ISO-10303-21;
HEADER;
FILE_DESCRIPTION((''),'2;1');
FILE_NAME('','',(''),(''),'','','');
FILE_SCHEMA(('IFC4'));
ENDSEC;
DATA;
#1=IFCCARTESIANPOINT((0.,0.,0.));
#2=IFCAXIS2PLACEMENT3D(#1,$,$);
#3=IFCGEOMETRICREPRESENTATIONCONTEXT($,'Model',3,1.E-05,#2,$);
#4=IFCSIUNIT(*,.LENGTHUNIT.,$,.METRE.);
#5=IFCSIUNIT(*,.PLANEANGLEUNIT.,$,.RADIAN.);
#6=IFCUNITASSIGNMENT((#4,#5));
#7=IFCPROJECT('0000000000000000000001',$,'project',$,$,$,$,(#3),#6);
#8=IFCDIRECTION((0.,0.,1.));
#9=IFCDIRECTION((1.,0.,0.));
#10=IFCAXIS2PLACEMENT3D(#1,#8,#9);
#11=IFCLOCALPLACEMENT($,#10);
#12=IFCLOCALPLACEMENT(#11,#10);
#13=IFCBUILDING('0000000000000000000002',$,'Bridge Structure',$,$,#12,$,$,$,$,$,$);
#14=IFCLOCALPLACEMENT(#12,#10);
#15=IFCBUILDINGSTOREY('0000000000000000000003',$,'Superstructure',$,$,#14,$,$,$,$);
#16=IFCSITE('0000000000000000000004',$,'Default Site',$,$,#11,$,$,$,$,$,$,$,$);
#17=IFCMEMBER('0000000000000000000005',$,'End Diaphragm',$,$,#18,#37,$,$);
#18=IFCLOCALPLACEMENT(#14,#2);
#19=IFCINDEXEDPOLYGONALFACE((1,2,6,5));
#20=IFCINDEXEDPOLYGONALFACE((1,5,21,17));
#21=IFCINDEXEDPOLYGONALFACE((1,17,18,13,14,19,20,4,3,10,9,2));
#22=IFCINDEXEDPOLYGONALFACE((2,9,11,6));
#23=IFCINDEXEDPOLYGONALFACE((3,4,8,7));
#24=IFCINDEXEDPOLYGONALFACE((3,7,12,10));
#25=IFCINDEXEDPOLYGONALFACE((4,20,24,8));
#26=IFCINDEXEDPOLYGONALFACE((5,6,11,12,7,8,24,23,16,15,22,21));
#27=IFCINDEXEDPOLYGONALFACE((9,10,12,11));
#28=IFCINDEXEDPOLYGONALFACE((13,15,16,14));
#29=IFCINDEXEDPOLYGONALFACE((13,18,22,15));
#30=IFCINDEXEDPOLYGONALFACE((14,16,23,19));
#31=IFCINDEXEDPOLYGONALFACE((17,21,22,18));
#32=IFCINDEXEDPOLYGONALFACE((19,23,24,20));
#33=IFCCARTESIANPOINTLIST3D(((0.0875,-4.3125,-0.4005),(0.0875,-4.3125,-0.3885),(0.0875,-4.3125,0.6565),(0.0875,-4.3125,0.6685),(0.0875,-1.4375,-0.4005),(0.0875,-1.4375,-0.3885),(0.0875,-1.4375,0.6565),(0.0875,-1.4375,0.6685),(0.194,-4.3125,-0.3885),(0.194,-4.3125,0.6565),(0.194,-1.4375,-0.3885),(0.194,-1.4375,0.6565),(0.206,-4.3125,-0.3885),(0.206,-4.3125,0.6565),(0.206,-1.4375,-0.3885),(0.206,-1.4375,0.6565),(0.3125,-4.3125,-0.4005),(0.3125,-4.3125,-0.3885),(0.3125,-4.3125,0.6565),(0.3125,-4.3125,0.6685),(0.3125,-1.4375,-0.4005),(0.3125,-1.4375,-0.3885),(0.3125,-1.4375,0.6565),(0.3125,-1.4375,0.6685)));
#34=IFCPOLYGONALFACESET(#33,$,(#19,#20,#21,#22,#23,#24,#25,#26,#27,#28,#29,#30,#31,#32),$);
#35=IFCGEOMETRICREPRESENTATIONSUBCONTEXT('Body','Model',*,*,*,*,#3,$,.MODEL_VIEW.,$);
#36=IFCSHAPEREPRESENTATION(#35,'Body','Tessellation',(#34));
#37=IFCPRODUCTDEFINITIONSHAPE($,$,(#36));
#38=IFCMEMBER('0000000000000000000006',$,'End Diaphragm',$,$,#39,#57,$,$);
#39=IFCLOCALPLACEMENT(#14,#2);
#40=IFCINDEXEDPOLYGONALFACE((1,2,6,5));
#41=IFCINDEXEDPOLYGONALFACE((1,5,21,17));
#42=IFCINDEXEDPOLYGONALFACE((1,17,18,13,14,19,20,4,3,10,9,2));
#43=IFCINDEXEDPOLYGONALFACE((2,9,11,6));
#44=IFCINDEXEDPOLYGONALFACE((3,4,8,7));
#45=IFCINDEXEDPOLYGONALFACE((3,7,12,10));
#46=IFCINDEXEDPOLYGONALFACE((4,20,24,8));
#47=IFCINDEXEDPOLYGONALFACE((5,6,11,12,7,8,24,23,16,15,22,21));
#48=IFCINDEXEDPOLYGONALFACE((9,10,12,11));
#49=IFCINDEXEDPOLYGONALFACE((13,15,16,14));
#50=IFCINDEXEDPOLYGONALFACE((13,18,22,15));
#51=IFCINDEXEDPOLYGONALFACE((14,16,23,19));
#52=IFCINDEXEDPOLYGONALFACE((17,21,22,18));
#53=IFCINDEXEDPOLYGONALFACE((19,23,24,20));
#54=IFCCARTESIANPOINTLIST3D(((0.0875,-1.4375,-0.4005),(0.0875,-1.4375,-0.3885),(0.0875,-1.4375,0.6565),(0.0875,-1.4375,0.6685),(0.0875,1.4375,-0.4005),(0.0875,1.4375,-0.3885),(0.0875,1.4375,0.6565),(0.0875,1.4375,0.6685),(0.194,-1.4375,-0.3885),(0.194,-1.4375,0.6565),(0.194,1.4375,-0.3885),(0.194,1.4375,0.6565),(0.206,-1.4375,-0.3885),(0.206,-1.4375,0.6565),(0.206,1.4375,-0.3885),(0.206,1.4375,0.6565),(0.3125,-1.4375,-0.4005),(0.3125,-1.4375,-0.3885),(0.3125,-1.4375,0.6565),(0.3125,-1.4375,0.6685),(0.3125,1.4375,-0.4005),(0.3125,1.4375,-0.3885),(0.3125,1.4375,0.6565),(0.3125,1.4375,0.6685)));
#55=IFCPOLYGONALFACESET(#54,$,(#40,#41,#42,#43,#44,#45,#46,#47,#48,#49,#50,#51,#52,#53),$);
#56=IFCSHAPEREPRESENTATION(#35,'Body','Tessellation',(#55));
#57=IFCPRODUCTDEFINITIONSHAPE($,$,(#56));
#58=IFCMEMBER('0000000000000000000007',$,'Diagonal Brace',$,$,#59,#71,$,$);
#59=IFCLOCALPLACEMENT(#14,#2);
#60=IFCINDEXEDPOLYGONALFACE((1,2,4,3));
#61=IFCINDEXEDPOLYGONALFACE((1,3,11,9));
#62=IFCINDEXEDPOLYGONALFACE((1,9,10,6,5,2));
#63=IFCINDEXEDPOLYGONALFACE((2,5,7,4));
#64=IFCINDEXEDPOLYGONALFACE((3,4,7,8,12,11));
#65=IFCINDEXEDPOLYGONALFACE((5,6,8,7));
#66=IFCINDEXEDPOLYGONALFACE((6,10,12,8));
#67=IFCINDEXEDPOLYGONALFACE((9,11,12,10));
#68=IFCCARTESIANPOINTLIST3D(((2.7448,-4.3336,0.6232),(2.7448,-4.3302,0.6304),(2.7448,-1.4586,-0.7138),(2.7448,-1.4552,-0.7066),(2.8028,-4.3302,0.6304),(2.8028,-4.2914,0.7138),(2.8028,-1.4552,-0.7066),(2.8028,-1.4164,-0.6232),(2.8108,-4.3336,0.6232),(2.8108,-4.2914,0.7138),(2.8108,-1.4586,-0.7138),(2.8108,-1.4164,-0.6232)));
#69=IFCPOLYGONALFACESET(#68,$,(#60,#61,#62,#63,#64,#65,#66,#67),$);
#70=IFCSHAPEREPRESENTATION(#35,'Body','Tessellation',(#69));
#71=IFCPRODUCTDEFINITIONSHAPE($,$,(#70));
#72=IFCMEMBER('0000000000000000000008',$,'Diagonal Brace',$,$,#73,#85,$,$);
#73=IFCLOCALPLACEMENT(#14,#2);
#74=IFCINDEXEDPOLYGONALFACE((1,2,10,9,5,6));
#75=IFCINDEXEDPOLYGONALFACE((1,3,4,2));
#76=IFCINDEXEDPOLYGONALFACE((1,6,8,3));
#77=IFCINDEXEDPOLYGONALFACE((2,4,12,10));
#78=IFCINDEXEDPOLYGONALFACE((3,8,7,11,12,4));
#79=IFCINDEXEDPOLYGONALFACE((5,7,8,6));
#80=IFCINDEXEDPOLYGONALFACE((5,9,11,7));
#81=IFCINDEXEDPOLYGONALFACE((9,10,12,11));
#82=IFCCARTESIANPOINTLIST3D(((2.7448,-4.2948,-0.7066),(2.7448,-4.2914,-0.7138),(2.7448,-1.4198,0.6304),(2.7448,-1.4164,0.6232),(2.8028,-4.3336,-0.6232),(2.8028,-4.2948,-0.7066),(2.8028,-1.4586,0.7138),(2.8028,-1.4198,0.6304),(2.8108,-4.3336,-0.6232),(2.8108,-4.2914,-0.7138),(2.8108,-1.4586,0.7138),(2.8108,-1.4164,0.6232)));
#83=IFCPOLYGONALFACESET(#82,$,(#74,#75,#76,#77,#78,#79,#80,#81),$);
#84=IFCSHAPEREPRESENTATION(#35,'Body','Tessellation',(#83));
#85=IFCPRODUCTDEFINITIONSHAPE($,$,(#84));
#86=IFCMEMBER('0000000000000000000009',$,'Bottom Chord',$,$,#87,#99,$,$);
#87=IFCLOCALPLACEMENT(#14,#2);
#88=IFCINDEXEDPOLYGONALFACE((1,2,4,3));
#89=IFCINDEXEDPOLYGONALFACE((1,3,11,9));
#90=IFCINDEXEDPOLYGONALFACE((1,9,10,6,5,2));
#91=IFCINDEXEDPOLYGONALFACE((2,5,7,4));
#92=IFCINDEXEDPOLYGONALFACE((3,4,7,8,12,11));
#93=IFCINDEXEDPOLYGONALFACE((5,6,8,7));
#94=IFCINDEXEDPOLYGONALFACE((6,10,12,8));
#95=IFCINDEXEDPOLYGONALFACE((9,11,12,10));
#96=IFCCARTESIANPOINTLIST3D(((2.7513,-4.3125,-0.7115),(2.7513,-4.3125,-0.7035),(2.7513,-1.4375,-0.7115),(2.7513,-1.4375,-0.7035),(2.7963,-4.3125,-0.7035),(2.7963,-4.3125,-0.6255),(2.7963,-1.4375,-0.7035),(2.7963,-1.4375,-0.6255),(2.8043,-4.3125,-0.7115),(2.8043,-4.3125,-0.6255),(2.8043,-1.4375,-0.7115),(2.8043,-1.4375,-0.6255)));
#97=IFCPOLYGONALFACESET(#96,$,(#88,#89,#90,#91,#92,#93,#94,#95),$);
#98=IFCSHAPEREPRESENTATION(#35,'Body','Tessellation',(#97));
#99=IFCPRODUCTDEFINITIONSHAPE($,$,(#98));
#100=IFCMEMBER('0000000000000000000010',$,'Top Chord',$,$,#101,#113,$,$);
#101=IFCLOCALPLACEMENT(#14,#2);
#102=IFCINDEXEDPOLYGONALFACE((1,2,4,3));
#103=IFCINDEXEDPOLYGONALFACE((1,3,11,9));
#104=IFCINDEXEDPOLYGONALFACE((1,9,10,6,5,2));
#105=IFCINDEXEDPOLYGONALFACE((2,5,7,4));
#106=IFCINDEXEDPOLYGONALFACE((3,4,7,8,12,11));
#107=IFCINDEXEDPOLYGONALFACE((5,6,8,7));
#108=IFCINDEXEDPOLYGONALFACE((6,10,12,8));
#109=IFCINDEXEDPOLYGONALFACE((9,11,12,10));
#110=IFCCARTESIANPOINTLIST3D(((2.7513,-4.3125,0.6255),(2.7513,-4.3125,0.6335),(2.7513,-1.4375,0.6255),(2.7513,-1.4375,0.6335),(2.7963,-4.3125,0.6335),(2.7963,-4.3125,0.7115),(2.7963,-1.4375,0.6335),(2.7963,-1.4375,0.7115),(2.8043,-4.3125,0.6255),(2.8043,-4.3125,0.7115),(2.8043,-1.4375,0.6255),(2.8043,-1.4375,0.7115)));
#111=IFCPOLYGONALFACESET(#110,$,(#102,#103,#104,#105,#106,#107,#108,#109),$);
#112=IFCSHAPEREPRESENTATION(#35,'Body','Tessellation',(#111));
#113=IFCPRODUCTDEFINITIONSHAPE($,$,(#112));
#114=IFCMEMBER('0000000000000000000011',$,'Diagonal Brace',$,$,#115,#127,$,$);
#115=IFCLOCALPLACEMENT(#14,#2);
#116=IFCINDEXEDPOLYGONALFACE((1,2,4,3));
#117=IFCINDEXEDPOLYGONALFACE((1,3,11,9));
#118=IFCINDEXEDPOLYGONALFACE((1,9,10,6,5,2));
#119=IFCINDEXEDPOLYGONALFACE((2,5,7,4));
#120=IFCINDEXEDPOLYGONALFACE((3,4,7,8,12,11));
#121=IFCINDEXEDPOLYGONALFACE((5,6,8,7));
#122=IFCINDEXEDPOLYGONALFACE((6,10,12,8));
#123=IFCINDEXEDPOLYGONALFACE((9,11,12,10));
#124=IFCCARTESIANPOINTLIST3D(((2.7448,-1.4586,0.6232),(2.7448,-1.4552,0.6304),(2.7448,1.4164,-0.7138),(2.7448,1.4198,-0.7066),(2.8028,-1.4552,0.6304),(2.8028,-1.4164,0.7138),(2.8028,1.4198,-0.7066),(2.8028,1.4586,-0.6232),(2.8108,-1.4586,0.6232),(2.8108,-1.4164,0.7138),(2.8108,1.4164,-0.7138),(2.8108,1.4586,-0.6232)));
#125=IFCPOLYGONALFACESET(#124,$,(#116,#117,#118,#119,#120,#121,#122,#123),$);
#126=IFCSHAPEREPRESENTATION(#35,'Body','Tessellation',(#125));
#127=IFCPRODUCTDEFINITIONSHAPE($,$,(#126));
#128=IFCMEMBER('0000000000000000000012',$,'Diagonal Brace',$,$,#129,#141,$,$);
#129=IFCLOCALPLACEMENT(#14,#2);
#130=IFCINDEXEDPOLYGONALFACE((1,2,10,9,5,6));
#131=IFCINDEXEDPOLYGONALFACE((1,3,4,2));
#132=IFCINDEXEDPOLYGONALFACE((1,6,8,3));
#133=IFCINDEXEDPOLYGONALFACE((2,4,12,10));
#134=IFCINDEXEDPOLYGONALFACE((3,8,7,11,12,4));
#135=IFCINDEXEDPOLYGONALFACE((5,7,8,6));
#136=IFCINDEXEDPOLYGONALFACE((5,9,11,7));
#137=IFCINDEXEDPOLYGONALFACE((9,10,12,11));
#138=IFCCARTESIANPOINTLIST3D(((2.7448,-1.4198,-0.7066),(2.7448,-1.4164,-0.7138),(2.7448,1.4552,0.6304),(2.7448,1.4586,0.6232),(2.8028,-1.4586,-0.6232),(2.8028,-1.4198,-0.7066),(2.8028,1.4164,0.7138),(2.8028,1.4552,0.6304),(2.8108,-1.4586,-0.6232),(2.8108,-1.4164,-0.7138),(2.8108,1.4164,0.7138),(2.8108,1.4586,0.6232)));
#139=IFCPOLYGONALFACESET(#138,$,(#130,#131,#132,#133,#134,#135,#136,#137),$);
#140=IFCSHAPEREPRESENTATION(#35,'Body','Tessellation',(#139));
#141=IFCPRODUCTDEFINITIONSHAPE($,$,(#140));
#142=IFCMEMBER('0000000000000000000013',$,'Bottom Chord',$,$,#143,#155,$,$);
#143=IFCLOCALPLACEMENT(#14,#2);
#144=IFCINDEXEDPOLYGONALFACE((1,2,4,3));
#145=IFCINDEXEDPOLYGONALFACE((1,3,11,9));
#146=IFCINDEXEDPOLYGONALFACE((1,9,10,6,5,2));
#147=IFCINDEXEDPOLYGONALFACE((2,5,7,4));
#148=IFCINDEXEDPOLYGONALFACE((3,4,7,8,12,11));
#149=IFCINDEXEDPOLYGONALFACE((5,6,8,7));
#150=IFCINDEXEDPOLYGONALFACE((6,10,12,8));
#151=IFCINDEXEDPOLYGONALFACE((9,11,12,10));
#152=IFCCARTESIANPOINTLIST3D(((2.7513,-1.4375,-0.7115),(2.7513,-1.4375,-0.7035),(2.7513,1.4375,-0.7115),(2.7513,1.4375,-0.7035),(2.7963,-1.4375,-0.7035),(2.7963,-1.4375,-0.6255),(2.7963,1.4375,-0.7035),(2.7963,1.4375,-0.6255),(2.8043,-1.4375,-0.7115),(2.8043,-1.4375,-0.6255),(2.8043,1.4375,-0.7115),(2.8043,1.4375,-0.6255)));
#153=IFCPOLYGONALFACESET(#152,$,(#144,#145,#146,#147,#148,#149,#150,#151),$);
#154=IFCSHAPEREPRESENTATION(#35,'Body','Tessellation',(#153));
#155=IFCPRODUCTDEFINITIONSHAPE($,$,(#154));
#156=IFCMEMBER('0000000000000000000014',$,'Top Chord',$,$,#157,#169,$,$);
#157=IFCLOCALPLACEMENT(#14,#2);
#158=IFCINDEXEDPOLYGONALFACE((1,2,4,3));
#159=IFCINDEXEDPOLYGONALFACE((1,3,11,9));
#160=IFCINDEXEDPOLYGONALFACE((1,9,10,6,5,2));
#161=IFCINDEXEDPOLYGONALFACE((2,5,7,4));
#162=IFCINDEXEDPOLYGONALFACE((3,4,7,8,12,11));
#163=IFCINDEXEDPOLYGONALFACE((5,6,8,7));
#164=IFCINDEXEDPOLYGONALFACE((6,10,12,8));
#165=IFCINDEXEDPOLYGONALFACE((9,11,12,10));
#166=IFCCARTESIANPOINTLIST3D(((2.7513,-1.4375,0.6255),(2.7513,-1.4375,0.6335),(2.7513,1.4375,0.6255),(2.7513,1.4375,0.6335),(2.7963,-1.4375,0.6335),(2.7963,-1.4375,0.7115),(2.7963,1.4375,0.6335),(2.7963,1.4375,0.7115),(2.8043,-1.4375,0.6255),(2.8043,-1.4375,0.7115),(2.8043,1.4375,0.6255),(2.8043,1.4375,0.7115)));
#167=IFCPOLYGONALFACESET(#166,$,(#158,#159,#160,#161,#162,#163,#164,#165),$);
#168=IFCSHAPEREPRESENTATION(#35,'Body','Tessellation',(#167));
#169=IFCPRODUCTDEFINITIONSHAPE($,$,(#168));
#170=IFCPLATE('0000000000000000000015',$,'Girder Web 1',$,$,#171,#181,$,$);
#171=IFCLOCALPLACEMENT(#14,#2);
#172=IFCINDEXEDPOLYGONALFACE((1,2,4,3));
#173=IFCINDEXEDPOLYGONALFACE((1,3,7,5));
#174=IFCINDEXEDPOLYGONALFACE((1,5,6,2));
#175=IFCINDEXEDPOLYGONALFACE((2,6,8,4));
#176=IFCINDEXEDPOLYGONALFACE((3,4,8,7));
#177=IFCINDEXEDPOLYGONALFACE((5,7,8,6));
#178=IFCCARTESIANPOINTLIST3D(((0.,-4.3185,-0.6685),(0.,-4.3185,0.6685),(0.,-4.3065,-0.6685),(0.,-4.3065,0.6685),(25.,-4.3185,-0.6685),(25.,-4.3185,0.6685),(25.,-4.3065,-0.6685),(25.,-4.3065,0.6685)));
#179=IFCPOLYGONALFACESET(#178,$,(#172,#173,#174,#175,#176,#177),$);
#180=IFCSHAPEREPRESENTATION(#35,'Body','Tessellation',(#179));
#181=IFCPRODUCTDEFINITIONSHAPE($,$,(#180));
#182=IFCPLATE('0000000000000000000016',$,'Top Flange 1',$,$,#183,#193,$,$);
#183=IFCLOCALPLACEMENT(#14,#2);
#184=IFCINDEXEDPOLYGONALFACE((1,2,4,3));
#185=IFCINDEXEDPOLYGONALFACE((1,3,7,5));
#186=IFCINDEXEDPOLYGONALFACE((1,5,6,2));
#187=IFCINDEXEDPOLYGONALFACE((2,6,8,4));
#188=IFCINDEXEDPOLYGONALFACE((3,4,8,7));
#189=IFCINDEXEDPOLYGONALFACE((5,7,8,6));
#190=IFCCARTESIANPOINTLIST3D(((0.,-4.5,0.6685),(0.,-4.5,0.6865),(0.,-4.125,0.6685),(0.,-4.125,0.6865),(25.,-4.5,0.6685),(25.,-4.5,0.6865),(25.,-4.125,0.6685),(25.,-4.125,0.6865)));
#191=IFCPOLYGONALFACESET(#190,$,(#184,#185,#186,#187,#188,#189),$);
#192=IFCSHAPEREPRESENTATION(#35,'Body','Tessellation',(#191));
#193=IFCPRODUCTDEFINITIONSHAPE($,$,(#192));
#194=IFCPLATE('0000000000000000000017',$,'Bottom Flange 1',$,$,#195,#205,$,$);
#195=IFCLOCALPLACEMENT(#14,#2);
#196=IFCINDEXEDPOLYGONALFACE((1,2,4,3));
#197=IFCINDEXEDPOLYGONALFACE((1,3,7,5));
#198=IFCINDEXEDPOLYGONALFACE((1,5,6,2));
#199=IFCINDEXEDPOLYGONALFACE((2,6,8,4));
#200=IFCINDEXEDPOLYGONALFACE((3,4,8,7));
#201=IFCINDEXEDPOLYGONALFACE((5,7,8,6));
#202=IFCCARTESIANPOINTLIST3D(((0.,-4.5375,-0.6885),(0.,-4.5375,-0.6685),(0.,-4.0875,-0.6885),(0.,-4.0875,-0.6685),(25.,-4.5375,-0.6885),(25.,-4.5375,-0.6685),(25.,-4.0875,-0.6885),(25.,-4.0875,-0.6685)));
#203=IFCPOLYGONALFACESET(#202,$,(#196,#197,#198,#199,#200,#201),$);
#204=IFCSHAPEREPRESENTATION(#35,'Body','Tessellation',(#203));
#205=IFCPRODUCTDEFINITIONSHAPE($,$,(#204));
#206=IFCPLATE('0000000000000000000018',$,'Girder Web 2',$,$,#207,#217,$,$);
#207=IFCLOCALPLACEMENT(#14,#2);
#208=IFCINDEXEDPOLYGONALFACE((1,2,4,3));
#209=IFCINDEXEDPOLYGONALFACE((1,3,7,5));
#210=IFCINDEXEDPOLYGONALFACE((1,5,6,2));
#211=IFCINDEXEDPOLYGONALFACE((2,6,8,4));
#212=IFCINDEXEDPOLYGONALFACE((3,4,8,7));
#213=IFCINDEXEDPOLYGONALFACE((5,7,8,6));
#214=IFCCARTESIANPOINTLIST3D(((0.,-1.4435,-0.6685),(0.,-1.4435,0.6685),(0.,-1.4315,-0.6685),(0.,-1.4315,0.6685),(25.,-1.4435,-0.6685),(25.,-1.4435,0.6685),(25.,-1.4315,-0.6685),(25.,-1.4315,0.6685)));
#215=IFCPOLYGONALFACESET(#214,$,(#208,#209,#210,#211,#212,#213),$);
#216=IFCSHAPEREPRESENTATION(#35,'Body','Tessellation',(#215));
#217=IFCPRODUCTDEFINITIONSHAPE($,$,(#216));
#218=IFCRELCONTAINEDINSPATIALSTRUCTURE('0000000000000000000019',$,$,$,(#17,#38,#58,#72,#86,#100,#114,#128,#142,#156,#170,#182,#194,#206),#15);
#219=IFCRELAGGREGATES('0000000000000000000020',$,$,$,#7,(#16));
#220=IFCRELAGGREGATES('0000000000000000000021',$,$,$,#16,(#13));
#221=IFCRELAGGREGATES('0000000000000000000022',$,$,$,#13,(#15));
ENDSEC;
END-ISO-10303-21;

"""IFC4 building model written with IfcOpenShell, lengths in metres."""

from ifc_helpers import new_model, si_unit, frame, origin, origin_with_axes, origin_2d_with_axis, place, context, subcontext, project, spatial, rectangle, i_section, l_section, extrude, element, save


model = new_model("IFC4")

# Units and contexts
model_context = context("Model", 3, precision=1e-05, world=origin())
body_context = subcontext(model_context, "Body", "Model", "MODEL_VIEW")
ifc_project = project(units=[si_unit("LENGTHUNIT", "METRE"), si_unit("PLANEANGLEUNIT", "RADIAN")], contexts=[model_context])

# Site, building, storey
site_placement = place(None, origin_with_axes())
site = spatial("IfcSite", under=ifc_project, at=site_placement, Name="Default Site")
building_placement = place(site_placement, origin_with_axes())
building = spatial("IfcBuilding", under=site, at=building_placement, Name="Bridge Structure")
storey_placement = place(building_placement, origin_with_axes())
storey = spatial("IfcBuildingStorey", under=building, at=storey_placement, Name="Superstructure")

# Members
for number, where, z_axis, x_axis, name in (
    (1, (0.2, -4.3125, 0.134), (0.0, 1.0, 0.0), (-1.0, 0.0, 0.0), "End Diaphragm"),
    (2, (0.2, -1.4375, 0.134), (0.0, 1.0, 0.0), (-1.0, 0.0, 0.0), "End Diaphragm"),
):
    element("IfcMember", number, at=place(storey_placement, frame(where, z_axis=z_axis, x_axis=x_axis)), inside=storey, Name=name, context=body_context, shape_type="SweptSolid", body=[
        extrude(i_section(OverallWidth=0.225, OverallDepth=1.069, WebThickness=0.012, FlangeThickness=0.012, at=origin_2d_with_axis()), origin_with_axes(), (0.0, 0.0, 1.0), 2.875),
    ])
for number, where, z_axis, x_axis, name in (
    (3, (2.7778, -4.3125, 0.6685), (0.0, 0.906746, -0.421676), (-1.0, 0.0, 0.0), "Diagonal Brace"),
    (4, (2.7778, -4.3125, -0.6685), (0.0, 0.906746, 0.421676), (-1.0, 0.0, 0.0), "Diagonal Brace"),
):
    element("IfcMember", number, at=place(storey_placement, frame(where, z_axis=z_axis, x_axis=x_axis)), inside=storey, Name=name, context=body_context, shape_type="SweptSolid", body=[
        extrude(l_section(Depth=0.1, Width=0.066, Thickness=0.008, at=origin_2d_with_axis()), origin_with_axes(), (0.0, 0.0, 1.0), 3.1707),
    ])
for number, where, z_axis, x_axis, name in (
    (5, (2.7778, -4.3125, -0.6685), (0.0, 1.0, 0.0), (-1.0, 0.0, 0.0), "Bottom Chord"),
    (6, (2.7778, -4.3125, 0.6685), (0.0, 1.0, 0.0), (-1.0, 0.0, 0.0), "Top Chord"),
):
    element("IfcMember", number, at=place(storey_placement, frame(where, z_axis=z_axis, x_axis=x_axis)), inside=storey, Name=name, context=body_context, shape_type="SweptSolid", body=[
        extrude(l_section(Depth=0.086, Width=0.053, Thickness=0.008, at=origin_2d_with_axis()), origin_with_axes(), (0.0, 0.0, 1.0), 2.875),
    ])
for number, where, z_axis, x_axis, name in (
    (7, (2.7778, -1.4375, 0.6685), (0.0, 0.906746, -0.421676), (-1.0, 0.0, 0.0), "Diagonal Brace"),
    (8, (2.7778, -1.4375, -0.6685), (0.0, 0.906746, 0.421676), (-1.0, 0.0, 0.0), "Diagonal Brace"),
):
    element("IfcMember", number, at=place(storey_placement, frame(where, z_axis=z_axis, x_axis=x_axis)), inside=storey, Name=name, context=body_context, shape_type="SweptSolid", body=[
        extrude(l_section(Depth=0.1, Width=0.066, Thickness=0.008, at=origin_2d_with_axis()), origin_with_axes(), (0.0, 0.0, 1.0), 3.1707),
    ])
for number, where, z_axis, x_axis, name in (
    (9, (2.7778, -1.4375, -0.6685), (0.0, 1.0, 0.0), (-1.0, 0.0, 0.0), "Bottom Chord"),
    (10, (2.7778, -1.4375, 0.6685), (0.0, 1.0, 0.0), (-1.0, 0.0, 0.0), "Top Chord"),
):
    element("IfcMember", number, at=place(storey_placement, frame(where, z_axis=z_axis, x_axis=x_axis)), inside=storey, Name=name, context=body_context, shape_type="SweptSolid", body=[
        extrude(l_section(Depth=0.086, Width=0.053, Thickness=0.008, at=origin_2d_with_axis()), origin_with_axes(), (0.0, 0.0, 1.0), 2.875),
    ])

# Plates
plate_1_placement = place(storey_placement, frame((0.0, -4.3125, 0.0), z_axis=(1.0, 0.0, 0.0), x_axis=(0.0, 1.0, 0.0)))
element("IfcPlate", 11, at=plate_1_placement, inside=storey, Name="Girder Web 1", context=body_context, shape_type="SweptSolid", body=[
    extrude(rectangle(XDim=0.012, YDim=1.337, at=origin_2d_with_axis()), origin_with_axes(), (0.0, 0.0, 1.0), 25.0),
])
plate_2_placement = place(storey_placement, frame((0.0, -4.3125, 0.6775), z_axis=(1.0, 0.0, 0.0), x_axis=(0.0, 1.0, 0.0)))
element("IfcPlate", 12, at=plate_2_placement, inside=storey, Name="Top Flange 1", context=body_context, shape_type="SweptSolid", body=[
    extrude(rectangle(XDim=0.375, YDim=0.018, at=origin_2d_with_axis()), origin_with_axes(), (0.0, 0.0, 1.0), 25.0),
])
plate_3_placement = place(storey_placement, frame((0.0, -4.3125, -0.6785), z_axis=(1.0, 0.0, 0.0), x_axis=(0.0, 1.0, 0.0)))
element("IfcPlate", 13, at=plate_3_placement, inside=storey, Name="Bottom Flange 1", context=body_context, shape_type="SweptSolid", body=[
    extrude(rectangle(XDim=0.45, YDim=0.02, at=origin_2d_with_axis()), origin_with_axes(), (0.0, 0.0, 1.0), 25.0),
])
plate_4_placement = place(storey_placement, frame((0.0, -1.4375, 0.0), z_axis=(1.0, 0.0, 0.0), x_axis=(0.0, 1.0, 0.0)))
element("IfcPlate", 14, at=plate_4_placement, inside=storey, Name="Girder Web 2", context=body_context, shape_type="SweptSolid", body=[
    extrude(rectangle(XDim=0.012, YDim=1.337, at=origin_2d_with_axis()), origin_with_axes(), (0.0, 0.0, 1.0), 25.0),
])

save(model, "model.ifc")
